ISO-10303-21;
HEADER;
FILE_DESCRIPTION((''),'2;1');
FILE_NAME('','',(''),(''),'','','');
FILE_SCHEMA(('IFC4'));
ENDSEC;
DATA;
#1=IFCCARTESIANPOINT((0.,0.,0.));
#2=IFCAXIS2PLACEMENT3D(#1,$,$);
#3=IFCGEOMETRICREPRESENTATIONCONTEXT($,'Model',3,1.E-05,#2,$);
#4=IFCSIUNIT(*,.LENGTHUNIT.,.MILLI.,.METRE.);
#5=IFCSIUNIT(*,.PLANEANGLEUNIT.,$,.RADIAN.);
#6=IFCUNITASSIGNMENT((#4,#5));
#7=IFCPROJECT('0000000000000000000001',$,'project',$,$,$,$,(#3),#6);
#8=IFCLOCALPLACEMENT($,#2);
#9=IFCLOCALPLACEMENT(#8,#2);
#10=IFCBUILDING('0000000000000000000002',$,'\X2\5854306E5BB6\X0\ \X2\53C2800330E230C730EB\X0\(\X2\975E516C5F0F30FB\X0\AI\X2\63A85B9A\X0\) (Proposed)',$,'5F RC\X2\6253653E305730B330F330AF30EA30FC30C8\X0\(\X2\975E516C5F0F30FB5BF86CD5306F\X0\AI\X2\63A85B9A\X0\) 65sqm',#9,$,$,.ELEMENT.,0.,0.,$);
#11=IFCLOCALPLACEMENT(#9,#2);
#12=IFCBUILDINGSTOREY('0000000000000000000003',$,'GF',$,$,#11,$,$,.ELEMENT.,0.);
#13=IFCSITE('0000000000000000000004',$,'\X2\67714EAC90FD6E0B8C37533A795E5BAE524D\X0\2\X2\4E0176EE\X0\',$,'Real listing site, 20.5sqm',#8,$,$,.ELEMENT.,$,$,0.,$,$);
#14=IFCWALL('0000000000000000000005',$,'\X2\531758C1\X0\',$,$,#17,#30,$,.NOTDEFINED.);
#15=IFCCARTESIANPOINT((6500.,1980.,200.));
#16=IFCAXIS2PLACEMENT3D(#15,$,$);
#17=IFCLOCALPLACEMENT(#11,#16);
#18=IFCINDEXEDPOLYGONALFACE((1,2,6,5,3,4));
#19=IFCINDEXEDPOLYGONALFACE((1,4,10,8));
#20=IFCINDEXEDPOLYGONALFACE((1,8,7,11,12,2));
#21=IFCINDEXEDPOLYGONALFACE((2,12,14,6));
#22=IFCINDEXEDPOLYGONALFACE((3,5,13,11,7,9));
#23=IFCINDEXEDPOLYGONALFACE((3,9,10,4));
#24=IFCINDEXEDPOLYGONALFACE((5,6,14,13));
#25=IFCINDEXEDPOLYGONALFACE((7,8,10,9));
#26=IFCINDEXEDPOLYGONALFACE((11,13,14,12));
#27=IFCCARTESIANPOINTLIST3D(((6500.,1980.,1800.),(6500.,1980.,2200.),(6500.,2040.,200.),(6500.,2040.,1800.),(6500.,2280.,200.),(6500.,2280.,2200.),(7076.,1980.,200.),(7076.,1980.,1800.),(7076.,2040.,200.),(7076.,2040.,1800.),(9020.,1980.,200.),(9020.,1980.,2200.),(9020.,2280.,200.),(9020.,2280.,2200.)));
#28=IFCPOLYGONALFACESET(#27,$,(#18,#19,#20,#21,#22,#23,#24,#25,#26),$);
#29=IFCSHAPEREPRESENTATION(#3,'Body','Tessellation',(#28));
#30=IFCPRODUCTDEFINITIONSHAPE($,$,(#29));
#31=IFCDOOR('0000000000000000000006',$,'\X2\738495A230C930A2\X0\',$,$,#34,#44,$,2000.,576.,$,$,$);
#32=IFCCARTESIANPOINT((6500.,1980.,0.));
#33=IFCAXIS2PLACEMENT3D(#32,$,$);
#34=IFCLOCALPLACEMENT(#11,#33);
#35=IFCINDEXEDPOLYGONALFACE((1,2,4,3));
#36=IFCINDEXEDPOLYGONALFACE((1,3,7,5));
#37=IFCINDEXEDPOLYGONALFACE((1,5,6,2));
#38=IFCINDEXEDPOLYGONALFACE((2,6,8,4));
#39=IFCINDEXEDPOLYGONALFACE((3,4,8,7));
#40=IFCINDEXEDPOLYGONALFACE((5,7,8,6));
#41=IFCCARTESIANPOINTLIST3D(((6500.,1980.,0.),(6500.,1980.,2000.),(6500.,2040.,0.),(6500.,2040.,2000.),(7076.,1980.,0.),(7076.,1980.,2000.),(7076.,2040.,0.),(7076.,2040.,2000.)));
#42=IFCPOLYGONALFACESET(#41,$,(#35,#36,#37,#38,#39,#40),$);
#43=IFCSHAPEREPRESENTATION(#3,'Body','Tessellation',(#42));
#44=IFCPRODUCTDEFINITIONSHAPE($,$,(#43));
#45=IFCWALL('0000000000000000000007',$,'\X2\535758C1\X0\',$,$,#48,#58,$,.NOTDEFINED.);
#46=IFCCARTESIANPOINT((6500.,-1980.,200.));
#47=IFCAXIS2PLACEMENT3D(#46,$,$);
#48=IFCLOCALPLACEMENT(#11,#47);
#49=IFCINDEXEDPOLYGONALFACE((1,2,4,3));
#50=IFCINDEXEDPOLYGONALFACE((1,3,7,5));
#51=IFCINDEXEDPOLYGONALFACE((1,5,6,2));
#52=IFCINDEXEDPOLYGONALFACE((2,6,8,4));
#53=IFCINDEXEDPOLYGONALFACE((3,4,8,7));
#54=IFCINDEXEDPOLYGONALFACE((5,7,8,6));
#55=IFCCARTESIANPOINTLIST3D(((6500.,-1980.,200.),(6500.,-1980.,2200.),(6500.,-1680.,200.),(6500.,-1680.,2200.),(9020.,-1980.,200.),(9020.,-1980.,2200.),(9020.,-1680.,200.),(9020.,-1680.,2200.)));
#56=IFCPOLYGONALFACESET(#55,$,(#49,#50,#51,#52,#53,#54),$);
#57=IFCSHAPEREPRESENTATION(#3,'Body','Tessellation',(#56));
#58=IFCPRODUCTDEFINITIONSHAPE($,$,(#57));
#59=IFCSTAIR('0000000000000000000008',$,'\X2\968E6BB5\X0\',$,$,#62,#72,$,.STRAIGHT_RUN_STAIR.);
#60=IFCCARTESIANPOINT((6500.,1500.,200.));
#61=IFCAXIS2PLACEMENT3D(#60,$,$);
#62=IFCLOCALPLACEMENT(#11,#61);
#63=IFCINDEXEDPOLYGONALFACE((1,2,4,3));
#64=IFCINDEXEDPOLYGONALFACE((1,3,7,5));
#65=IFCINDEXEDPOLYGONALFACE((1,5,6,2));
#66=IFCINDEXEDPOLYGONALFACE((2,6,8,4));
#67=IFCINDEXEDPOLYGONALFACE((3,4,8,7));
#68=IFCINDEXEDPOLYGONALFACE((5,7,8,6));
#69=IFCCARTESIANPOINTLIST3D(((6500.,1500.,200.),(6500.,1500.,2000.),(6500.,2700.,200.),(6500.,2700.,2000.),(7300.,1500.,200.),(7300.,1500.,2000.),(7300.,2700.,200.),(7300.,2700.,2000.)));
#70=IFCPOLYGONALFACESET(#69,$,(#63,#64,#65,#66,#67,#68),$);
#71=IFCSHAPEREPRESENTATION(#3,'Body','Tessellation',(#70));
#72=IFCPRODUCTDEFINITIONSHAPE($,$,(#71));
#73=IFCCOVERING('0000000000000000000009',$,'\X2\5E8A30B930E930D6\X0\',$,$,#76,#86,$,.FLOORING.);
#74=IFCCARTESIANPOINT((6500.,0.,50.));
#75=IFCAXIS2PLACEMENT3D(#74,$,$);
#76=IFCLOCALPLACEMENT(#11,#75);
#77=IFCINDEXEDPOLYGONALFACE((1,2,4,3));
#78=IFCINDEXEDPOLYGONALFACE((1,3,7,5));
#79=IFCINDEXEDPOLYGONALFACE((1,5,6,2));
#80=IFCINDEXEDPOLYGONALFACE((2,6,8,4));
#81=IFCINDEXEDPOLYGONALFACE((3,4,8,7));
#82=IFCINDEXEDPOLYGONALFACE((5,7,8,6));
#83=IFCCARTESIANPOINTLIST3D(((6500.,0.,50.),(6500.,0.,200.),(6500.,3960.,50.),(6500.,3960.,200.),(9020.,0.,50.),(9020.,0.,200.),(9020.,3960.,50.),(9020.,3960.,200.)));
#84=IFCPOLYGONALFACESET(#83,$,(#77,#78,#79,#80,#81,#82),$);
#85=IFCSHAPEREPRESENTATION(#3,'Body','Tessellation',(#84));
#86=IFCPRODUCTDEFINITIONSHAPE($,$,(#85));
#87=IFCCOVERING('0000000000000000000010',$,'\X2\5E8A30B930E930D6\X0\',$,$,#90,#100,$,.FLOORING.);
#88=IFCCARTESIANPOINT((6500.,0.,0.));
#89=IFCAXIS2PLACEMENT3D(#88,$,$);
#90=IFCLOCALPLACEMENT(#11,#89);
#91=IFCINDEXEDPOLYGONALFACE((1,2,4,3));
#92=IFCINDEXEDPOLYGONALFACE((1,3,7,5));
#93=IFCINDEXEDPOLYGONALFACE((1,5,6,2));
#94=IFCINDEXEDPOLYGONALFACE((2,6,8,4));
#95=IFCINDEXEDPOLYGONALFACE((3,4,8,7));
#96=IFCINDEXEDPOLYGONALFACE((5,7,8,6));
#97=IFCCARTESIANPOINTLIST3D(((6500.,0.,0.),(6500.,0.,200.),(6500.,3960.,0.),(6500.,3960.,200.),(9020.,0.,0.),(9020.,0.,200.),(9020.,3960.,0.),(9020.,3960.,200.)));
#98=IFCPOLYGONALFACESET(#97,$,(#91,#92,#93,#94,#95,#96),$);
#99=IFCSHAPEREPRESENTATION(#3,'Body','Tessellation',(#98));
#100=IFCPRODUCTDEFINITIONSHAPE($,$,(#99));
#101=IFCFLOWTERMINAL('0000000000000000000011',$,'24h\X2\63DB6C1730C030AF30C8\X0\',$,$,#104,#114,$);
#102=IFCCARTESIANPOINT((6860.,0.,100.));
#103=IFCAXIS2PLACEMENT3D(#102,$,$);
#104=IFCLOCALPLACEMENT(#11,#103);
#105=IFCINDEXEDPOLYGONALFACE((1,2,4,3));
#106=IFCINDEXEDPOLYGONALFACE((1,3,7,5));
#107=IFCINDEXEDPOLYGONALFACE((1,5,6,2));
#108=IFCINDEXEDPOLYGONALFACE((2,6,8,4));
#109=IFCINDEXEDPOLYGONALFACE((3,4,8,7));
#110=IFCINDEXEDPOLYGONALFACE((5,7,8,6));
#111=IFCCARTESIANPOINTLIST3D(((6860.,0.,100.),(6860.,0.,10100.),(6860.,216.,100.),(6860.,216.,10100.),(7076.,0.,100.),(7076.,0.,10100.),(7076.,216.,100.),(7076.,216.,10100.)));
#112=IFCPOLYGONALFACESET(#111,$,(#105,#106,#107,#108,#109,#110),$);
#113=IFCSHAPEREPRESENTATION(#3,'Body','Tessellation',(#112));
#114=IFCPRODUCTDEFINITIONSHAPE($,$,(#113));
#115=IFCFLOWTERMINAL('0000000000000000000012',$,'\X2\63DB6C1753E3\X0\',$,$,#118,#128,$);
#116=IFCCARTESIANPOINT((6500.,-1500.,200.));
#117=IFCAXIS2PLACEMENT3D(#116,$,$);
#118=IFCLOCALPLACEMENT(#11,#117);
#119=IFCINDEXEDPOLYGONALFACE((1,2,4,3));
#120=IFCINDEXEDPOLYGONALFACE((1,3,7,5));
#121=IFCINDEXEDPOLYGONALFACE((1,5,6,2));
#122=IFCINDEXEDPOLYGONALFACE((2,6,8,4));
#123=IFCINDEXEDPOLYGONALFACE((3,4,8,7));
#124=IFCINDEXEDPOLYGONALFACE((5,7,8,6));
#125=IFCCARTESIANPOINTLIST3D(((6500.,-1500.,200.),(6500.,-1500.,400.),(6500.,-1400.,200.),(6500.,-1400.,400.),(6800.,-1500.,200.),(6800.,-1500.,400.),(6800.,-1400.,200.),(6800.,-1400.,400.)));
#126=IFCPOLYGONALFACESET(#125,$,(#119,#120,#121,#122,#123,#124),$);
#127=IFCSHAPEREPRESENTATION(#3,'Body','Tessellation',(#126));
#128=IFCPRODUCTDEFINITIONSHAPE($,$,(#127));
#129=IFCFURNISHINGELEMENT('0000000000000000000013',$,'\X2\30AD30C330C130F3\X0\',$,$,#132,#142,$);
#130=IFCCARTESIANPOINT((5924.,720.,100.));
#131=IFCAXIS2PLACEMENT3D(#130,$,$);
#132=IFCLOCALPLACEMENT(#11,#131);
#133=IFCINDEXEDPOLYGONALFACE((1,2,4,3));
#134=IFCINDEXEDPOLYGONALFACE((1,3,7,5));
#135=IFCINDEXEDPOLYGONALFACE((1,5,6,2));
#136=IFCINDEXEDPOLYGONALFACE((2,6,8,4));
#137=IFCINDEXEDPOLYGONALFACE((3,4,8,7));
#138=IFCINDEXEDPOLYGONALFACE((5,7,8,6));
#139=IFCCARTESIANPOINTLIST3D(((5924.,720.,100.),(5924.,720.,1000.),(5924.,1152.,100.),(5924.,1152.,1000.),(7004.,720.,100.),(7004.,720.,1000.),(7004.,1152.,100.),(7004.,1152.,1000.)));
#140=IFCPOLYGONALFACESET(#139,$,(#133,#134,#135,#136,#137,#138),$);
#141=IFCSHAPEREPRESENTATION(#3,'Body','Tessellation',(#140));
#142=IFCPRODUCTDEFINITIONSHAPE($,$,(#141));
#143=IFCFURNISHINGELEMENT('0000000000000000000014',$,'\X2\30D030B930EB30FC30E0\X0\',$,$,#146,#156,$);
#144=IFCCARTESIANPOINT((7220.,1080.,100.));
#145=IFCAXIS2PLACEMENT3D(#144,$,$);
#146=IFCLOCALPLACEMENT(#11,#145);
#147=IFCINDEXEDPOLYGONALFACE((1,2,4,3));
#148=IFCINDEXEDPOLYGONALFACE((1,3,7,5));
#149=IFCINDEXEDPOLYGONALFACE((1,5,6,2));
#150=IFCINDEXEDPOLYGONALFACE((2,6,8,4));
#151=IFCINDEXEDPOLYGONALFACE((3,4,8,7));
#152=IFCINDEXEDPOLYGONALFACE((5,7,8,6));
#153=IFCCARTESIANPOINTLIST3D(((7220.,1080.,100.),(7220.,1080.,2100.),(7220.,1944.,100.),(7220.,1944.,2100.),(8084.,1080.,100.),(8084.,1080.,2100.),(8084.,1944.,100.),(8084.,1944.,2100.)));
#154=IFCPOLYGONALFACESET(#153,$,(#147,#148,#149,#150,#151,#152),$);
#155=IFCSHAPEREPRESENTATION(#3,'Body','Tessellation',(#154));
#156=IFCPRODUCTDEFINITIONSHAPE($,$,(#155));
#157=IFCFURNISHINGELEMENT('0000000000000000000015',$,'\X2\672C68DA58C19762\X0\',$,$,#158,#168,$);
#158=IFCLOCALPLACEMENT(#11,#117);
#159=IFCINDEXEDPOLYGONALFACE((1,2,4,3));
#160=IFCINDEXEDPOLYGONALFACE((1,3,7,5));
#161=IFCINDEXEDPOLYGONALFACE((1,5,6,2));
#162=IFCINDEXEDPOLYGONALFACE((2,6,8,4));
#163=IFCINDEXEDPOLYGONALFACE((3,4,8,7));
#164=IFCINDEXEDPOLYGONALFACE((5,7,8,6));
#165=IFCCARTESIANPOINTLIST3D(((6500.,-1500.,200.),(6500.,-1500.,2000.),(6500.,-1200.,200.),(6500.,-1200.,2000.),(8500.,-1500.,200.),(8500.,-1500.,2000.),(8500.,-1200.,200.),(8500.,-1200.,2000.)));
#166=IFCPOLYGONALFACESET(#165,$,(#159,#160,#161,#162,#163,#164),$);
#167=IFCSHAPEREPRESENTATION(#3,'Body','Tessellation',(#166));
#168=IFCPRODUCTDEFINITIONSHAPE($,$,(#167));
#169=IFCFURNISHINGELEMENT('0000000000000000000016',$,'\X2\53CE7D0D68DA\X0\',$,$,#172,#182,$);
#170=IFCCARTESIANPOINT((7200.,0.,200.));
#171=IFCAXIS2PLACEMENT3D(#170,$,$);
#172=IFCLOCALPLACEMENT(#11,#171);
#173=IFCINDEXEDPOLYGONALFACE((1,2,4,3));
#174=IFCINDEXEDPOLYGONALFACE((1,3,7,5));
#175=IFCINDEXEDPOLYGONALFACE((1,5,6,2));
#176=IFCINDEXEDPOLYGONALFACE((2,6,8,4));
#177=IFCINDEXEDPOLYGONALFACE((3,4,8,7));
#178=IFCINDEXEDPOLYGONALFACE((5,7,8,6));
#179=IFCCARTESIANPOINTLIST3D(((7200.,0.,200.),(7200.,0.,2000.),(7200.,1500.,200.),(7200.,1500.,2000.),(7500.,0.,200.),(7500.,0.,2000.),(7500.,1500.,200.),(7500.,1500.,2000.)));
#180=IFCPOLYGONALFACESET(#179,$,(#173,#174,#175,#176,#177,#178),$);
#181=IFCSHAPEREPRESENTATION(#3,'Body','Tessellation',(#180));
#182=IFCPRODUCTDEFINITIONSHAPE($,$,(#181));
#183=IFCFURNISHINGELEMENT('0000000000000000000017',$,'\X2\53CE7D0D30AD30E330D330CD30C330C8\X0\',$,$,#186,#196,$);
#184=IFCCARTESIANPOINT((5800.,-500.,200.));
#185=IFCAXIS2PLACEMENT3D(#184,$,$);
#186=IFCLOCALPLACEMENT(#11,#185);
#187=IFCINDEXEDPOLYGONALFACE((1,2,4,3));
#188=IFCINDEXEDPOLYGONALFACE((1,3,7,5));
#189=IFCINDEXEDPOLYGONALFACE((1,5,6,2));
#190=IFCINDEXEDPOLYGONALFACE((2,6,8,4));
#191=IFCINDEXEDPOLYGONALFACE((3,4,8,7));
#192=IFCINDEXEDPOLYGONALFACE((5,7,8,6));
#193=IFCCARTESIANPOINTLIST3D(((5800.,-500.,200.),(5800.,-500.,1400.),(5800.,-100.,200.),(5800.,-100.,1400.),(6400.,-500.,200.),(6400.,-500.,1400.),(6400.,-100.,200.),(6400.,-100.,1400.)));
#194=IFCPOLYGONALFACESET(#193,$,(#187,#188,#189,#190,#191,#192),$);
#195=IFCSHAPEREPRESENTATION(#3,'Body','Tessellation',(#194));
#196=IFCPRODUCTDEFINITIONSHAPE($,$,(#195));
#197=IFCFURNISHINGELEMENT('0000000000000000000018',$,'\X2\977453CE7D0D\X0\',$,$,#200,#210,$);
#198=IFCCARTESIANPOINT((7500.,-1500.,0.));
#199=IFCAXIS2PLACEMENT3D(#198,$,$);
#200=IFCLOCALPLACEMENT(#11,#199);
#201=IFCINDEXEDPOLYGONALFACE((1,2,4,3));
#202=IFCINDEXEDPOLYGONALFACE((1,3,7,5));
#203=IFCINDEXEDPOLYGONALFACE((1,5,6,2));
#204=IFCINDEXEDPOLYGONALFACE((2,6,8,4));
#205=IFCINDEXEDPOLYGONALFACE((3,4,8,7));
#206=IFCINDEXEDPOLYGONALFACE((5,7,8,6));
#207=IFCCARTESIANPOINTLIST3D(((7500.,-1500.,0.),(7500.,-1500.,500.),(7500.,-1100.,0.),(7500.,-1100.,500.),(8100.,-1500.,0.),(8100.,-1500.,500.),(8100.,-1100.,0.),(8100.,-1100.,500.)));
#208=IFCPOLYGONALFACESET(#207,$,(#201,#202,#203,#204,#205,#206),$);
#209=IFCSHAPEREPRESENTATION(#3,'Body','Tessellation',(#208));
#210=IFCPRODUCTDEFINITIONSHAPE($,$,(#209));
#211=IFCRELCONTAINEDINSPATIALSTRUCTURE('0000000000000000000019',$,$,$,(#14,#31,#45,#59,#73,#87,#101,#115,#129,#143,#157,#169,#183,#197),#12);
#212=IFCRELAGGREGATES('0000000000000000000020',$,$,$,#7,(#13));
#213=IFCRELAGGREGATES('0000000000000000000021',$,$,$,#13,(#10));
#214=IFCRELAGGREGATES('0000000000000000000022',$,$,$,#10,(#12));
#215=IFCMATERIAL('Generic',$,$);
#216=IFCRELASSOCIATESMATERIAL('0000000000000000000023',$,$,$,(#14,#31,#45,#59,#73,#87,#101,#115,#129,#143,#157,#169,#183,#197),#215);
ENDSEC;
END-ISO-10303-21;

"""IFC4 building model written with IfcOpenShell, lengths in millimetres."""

from ifc_helpers import new_model, si_unit, frame, frame_2d, origin, place, context, project, spatial, rectangle, extrude, material, element, fill, save


model = new_model("IFC4")

# Units and contexts
model_context = context("Model", 3, precision=1e-05, world=origin())
ifc_project = project(units=[si_unit("LENGTHUNIT", "METRE", prefix="MILLI"), si_unit("PLANEANGLEUNIT", "RADIAN")], contexts=[model_context])

# Site, building, storey
site_placement = place(None, origin())
site = spatial("IfcSite", under=ifc_project, at=site_placement, Name="東京都渋谷区神宮前2丁目", ObjectType="Real listing site, 20.5sqm", CompositionType="ELEMENT", RefElevation=0.0)
building_placement = place(site_placement, origin())
building = spatial("IfcBuilding", under=site, at=building_placement, Name="塔の家 参考モデル(非公式・AI推定) (Proposed)", ObjectType="5F RC打放しコンクリート(非公式・寸法はAI推定) 65sqm", CompositionType="ELEMENT", ElevationOfRefHeight=0.0, ElevationOfTerrain=0.0)
storey_placement = place(building_placement, origin())
storey = spatial("IfcBuildingStorey", under=building, at=storey_placement, Name="GF", CompositionType="ELEMENT", Elevation=0.0)

# Shared definitions
ifc_material = material(Name="Generic")

# Wall, opening, door
wall_1_placement = place(storey_placement, frame((6500.0, 1980.0, 200.0)))
wall_1 = element("IfcWall", 1, at=wall_1_placement, inside=storey, material=ifc_material, Name="北壁", PredefinedType="NOTDEFINED", context=model_context, shape_type="SweptSolid", body=[
    extrude(rectangle(XDim=2520.0, YDim=300.0, at=frame_2d((1260.0, 150.0))), frame((6500.0, 1980.0, 200.0)), (0.0, 0.0, 1.0), 2000.0),
])
opening_1_placement = place(storey_placement, frame((6500.0, 1980.0, 0.0)))
opening_1 = element("IfcOpeningElement", 2, at=opening_1_placement, cuts=wall_1, PredefinedType="NOTDEFINED", context=model_context, shape_type="SweptSolid", body=[
    extrude(rectangle(XDim=576.0, YDim=60.0, at=frame_2d((288.0, 30.0))), frame((6500.0, 1980.0, 0.0)), (0.0, 0.0, 1.0), 2000.0),
])
door_1_placement = place(storey_placement, frame((6500.0, 1980.0, 0.0)))
door_1 = element("IfcDoor", 3, at=door_1_placement, inside=storey, material=ifc_material, Name="玄関ドア", OverallHeight=2000.0, OverallWidth=576.0, context=model_context, shape_type="SweptSolid", body=[
    extrude(rectangle(XDim=576.0, YDim=60.0, at=frame_2d((288.0, 30.0))), frame((6500.0, 1980.0, 0.0)), (0.0, 0.0, 1.0), 2000.0),
])
fill(opening_1, door_1)

# Wall
wall_2_placement = place(storey_placement, frame((6500.0, -1980.0, 200.0)))
element("IfcWall", 4, at=wall_2_placement, inside=storey, material=ifc_material, Name="南壁", PredefinedType="NOTDEFINED", context=model_context, shape_type="SweptSolid", body=[
    extrude(rectangle(XDim=2520.0, YDim=300.0, at=frame_2d((1260.0, 150.0))), frame((6500.0, -1980.0, 200.0)), (0.0, 0.0, 1.0), 2000.0),
])

# Stair
stair_placement = place(storey_placement, frame((6500.0, 1500.0, 200.0)))
element("IfcStair", 5, at=stair_placement, inside=storey, material=ifc_material, Name="階段", PredefinedType="STRAIGHT_RUN_STAIR", context=model_context, shape_type="SweptSolid", body=[
    extrude(rectangle(XDim=800.0, YDim=1200.0, at=frame_2d((400.0, 600.0))), frame((6500.0, 1500.0, 200.0)), (0.0, 0.0, 1.0), 1800.0),
])

# Coverings
covering_1_placement = place(storey_placement, frame((6500.0, 0.0, 50.0)))
element("IfcCovering", 6, at=covering_1_placement, inside=storey, material=ifc_material, Name="床スラブ", PredefinedType="FLOORING", context=model_context, shape_type="SweptSolid", body=[
    extrude(rectangle(XDim=2520.0, YDim=3960.0, at=frame_2d((1260.0, 1980.0))), frame((6500.0, 0.0, 50.0)), (0.0, 0.0, 1.0), 150.0),
])
covering_2_placement = place(storey_placement, frame((6500.0, 0.0, 0.0)))
element("IfcCovering", 7, at=covering_2_placement, inside=storey, material=ifc_material, Name="床スラブ", PredefinedType="FLOORING", context=model_context, shape_type="SweptSolid", body=[
    extrude(rectangle(XDim=2520.0, YDim=3960.0, at=frame_2d((1260.0, 1980.0))), frame((6500.0, 0.0, 0.0)), (0.0, 0.0, 1.0), 200.0),
])

# Flow terminals
flow_terminal_1_placement = place(storey_placement, frame((6860.0, 0.0, 100.0)))
element("IfcFlowTerminal", 8, at=flow_terminal_1_placement, inside=storey, material=ifc_material, Name="24h換気ダクト", context=model_context, shape_type="SweptSolid", body=[
    extrude(rectangle(XDim=216.0, YDim=216.0, at=frame_2d((108.0, 108.0))), frame((6860.0, 0.0, 100.0)), (0.0, 0.0, 1.0), 10000.0),
])
flow_terminal_2_placement = place(storey_placement, frame((6500.0, -1500.0, 200.0)))
element("IfcFlowTerminal", 9, at=flow_terminal_2_placement, inside=storey, material=ifc_material, Name="換気口", context=model_context, shape_type="SweptSolid", body=[
    extrude(rectangle(XDim=300.0, YDim=100.0, at=frame_2d((150.0, 50.0))), frame((6500.0, -1500.0, 200.0)), (0.0, 0.0, 1.0), 200.0),
])

# Furnishing elements
furnishing_1_placement = place(storey_placement, frame((5924.0, 720.0, 100.0)))
element("IfcFurnishingElement", 10, at=furnishing_1_placement, inside=storey, material=ifc_material, Name="キッチン", context=model_context, shape_type="SweptSolid", body=[
    extrude(rectangle(XDim=1080.0, YDim=432.0, at=frame_2d((540.0, 216.0))), frame((5924.0, 720.0, 100.0)), (0.0, 0.0, 1.0), 900.0),
])
furnishing_2_placement = place(storey_placement, frame((7220.0, 1080.0, 100.0)))
element("IfcFurnishingElement", 11, at=furnishing_2_placement, inside=storey, material=ifc_material, Name="バスルーム", context=model_context, shape_type="SweptSolid", body=[
    extrude(rectangle(XDim=864.0, YDim=864.0, at=frame_2d((432.0, 432.0))), frame((7220.0, 1080.0, 100.0)), (0.0, 0.0, 1.0), 2000.0),
])
furnishing_3_placement = place(storey_placement, frame((6500.0, -1500.0, 200.0)))
element("IfcFurnishingElement", 12, at=furnishing_3_placement, inside=storey, material=ifc_material, Name="本棚壁面", context=model_context, shape_type="SweptSolid", body=[
    extrude(rectangle(XDim=2000.0, YDim=300.0, at=frame_2d((1000.0, 150.0))), frame((6500.0, -1500.0, 200.0)), (0.0, 0.0, 1.0), 1800.0),
])
furnishing_4_placement = place(storey_placement, frame((7200.0, 0.0, 200.0)))
element("IfcFurnishingElement", 13, at=furnishing_4_placement, inside=storey, material=ifc_material, Name="収納棚", context=model_context, shape_type="SweptSolid", body=[
    extrude(rectangle(XDim=300.0, YDim=1500.0, at=frame_2d((150.0, 750.0))), frame((7200.0, 0.0, 200.0)), (0.0, 0.0, 1.0), 1800.0),
])
furnishing_5_placement = place(storey_placement, frame((5800.0, -500.0, 200.0)))
element("IfcFurnishingElement", 14, at=furnishing_5_placement, inside=storey, material=ifc_material, Name="収納キャビネット", context=model_context, shape_type="SweptSolid", body=[
    extrude(rectangle(XDim=600.0, YDim=400.0, at=frame_2d((300.0, 200.0))), frame((5800.0, -500.0, 200.0)), (0.0, 0.0, 1.0), 1200.0),
])
furnishing_6_placement = place(storey_placement, frame((7500.0, -1500.0, 0.0)))
element("IfcFurnishingElement", 15, at=furnishing_6_placement, inside=storey, material=ifc_material, Name="靴収納", context=model_context, shape_type="SweptSolid", body=[
    extrude(rectangle(XDim=600.0, YDim=400.0, at=frame_2d((300.0, 200.0))), frame((7500.0, -1500.0, 0.0)), (0.0, 0.0, 1.0), 500.0),
])

save(model, "model.ifc")
